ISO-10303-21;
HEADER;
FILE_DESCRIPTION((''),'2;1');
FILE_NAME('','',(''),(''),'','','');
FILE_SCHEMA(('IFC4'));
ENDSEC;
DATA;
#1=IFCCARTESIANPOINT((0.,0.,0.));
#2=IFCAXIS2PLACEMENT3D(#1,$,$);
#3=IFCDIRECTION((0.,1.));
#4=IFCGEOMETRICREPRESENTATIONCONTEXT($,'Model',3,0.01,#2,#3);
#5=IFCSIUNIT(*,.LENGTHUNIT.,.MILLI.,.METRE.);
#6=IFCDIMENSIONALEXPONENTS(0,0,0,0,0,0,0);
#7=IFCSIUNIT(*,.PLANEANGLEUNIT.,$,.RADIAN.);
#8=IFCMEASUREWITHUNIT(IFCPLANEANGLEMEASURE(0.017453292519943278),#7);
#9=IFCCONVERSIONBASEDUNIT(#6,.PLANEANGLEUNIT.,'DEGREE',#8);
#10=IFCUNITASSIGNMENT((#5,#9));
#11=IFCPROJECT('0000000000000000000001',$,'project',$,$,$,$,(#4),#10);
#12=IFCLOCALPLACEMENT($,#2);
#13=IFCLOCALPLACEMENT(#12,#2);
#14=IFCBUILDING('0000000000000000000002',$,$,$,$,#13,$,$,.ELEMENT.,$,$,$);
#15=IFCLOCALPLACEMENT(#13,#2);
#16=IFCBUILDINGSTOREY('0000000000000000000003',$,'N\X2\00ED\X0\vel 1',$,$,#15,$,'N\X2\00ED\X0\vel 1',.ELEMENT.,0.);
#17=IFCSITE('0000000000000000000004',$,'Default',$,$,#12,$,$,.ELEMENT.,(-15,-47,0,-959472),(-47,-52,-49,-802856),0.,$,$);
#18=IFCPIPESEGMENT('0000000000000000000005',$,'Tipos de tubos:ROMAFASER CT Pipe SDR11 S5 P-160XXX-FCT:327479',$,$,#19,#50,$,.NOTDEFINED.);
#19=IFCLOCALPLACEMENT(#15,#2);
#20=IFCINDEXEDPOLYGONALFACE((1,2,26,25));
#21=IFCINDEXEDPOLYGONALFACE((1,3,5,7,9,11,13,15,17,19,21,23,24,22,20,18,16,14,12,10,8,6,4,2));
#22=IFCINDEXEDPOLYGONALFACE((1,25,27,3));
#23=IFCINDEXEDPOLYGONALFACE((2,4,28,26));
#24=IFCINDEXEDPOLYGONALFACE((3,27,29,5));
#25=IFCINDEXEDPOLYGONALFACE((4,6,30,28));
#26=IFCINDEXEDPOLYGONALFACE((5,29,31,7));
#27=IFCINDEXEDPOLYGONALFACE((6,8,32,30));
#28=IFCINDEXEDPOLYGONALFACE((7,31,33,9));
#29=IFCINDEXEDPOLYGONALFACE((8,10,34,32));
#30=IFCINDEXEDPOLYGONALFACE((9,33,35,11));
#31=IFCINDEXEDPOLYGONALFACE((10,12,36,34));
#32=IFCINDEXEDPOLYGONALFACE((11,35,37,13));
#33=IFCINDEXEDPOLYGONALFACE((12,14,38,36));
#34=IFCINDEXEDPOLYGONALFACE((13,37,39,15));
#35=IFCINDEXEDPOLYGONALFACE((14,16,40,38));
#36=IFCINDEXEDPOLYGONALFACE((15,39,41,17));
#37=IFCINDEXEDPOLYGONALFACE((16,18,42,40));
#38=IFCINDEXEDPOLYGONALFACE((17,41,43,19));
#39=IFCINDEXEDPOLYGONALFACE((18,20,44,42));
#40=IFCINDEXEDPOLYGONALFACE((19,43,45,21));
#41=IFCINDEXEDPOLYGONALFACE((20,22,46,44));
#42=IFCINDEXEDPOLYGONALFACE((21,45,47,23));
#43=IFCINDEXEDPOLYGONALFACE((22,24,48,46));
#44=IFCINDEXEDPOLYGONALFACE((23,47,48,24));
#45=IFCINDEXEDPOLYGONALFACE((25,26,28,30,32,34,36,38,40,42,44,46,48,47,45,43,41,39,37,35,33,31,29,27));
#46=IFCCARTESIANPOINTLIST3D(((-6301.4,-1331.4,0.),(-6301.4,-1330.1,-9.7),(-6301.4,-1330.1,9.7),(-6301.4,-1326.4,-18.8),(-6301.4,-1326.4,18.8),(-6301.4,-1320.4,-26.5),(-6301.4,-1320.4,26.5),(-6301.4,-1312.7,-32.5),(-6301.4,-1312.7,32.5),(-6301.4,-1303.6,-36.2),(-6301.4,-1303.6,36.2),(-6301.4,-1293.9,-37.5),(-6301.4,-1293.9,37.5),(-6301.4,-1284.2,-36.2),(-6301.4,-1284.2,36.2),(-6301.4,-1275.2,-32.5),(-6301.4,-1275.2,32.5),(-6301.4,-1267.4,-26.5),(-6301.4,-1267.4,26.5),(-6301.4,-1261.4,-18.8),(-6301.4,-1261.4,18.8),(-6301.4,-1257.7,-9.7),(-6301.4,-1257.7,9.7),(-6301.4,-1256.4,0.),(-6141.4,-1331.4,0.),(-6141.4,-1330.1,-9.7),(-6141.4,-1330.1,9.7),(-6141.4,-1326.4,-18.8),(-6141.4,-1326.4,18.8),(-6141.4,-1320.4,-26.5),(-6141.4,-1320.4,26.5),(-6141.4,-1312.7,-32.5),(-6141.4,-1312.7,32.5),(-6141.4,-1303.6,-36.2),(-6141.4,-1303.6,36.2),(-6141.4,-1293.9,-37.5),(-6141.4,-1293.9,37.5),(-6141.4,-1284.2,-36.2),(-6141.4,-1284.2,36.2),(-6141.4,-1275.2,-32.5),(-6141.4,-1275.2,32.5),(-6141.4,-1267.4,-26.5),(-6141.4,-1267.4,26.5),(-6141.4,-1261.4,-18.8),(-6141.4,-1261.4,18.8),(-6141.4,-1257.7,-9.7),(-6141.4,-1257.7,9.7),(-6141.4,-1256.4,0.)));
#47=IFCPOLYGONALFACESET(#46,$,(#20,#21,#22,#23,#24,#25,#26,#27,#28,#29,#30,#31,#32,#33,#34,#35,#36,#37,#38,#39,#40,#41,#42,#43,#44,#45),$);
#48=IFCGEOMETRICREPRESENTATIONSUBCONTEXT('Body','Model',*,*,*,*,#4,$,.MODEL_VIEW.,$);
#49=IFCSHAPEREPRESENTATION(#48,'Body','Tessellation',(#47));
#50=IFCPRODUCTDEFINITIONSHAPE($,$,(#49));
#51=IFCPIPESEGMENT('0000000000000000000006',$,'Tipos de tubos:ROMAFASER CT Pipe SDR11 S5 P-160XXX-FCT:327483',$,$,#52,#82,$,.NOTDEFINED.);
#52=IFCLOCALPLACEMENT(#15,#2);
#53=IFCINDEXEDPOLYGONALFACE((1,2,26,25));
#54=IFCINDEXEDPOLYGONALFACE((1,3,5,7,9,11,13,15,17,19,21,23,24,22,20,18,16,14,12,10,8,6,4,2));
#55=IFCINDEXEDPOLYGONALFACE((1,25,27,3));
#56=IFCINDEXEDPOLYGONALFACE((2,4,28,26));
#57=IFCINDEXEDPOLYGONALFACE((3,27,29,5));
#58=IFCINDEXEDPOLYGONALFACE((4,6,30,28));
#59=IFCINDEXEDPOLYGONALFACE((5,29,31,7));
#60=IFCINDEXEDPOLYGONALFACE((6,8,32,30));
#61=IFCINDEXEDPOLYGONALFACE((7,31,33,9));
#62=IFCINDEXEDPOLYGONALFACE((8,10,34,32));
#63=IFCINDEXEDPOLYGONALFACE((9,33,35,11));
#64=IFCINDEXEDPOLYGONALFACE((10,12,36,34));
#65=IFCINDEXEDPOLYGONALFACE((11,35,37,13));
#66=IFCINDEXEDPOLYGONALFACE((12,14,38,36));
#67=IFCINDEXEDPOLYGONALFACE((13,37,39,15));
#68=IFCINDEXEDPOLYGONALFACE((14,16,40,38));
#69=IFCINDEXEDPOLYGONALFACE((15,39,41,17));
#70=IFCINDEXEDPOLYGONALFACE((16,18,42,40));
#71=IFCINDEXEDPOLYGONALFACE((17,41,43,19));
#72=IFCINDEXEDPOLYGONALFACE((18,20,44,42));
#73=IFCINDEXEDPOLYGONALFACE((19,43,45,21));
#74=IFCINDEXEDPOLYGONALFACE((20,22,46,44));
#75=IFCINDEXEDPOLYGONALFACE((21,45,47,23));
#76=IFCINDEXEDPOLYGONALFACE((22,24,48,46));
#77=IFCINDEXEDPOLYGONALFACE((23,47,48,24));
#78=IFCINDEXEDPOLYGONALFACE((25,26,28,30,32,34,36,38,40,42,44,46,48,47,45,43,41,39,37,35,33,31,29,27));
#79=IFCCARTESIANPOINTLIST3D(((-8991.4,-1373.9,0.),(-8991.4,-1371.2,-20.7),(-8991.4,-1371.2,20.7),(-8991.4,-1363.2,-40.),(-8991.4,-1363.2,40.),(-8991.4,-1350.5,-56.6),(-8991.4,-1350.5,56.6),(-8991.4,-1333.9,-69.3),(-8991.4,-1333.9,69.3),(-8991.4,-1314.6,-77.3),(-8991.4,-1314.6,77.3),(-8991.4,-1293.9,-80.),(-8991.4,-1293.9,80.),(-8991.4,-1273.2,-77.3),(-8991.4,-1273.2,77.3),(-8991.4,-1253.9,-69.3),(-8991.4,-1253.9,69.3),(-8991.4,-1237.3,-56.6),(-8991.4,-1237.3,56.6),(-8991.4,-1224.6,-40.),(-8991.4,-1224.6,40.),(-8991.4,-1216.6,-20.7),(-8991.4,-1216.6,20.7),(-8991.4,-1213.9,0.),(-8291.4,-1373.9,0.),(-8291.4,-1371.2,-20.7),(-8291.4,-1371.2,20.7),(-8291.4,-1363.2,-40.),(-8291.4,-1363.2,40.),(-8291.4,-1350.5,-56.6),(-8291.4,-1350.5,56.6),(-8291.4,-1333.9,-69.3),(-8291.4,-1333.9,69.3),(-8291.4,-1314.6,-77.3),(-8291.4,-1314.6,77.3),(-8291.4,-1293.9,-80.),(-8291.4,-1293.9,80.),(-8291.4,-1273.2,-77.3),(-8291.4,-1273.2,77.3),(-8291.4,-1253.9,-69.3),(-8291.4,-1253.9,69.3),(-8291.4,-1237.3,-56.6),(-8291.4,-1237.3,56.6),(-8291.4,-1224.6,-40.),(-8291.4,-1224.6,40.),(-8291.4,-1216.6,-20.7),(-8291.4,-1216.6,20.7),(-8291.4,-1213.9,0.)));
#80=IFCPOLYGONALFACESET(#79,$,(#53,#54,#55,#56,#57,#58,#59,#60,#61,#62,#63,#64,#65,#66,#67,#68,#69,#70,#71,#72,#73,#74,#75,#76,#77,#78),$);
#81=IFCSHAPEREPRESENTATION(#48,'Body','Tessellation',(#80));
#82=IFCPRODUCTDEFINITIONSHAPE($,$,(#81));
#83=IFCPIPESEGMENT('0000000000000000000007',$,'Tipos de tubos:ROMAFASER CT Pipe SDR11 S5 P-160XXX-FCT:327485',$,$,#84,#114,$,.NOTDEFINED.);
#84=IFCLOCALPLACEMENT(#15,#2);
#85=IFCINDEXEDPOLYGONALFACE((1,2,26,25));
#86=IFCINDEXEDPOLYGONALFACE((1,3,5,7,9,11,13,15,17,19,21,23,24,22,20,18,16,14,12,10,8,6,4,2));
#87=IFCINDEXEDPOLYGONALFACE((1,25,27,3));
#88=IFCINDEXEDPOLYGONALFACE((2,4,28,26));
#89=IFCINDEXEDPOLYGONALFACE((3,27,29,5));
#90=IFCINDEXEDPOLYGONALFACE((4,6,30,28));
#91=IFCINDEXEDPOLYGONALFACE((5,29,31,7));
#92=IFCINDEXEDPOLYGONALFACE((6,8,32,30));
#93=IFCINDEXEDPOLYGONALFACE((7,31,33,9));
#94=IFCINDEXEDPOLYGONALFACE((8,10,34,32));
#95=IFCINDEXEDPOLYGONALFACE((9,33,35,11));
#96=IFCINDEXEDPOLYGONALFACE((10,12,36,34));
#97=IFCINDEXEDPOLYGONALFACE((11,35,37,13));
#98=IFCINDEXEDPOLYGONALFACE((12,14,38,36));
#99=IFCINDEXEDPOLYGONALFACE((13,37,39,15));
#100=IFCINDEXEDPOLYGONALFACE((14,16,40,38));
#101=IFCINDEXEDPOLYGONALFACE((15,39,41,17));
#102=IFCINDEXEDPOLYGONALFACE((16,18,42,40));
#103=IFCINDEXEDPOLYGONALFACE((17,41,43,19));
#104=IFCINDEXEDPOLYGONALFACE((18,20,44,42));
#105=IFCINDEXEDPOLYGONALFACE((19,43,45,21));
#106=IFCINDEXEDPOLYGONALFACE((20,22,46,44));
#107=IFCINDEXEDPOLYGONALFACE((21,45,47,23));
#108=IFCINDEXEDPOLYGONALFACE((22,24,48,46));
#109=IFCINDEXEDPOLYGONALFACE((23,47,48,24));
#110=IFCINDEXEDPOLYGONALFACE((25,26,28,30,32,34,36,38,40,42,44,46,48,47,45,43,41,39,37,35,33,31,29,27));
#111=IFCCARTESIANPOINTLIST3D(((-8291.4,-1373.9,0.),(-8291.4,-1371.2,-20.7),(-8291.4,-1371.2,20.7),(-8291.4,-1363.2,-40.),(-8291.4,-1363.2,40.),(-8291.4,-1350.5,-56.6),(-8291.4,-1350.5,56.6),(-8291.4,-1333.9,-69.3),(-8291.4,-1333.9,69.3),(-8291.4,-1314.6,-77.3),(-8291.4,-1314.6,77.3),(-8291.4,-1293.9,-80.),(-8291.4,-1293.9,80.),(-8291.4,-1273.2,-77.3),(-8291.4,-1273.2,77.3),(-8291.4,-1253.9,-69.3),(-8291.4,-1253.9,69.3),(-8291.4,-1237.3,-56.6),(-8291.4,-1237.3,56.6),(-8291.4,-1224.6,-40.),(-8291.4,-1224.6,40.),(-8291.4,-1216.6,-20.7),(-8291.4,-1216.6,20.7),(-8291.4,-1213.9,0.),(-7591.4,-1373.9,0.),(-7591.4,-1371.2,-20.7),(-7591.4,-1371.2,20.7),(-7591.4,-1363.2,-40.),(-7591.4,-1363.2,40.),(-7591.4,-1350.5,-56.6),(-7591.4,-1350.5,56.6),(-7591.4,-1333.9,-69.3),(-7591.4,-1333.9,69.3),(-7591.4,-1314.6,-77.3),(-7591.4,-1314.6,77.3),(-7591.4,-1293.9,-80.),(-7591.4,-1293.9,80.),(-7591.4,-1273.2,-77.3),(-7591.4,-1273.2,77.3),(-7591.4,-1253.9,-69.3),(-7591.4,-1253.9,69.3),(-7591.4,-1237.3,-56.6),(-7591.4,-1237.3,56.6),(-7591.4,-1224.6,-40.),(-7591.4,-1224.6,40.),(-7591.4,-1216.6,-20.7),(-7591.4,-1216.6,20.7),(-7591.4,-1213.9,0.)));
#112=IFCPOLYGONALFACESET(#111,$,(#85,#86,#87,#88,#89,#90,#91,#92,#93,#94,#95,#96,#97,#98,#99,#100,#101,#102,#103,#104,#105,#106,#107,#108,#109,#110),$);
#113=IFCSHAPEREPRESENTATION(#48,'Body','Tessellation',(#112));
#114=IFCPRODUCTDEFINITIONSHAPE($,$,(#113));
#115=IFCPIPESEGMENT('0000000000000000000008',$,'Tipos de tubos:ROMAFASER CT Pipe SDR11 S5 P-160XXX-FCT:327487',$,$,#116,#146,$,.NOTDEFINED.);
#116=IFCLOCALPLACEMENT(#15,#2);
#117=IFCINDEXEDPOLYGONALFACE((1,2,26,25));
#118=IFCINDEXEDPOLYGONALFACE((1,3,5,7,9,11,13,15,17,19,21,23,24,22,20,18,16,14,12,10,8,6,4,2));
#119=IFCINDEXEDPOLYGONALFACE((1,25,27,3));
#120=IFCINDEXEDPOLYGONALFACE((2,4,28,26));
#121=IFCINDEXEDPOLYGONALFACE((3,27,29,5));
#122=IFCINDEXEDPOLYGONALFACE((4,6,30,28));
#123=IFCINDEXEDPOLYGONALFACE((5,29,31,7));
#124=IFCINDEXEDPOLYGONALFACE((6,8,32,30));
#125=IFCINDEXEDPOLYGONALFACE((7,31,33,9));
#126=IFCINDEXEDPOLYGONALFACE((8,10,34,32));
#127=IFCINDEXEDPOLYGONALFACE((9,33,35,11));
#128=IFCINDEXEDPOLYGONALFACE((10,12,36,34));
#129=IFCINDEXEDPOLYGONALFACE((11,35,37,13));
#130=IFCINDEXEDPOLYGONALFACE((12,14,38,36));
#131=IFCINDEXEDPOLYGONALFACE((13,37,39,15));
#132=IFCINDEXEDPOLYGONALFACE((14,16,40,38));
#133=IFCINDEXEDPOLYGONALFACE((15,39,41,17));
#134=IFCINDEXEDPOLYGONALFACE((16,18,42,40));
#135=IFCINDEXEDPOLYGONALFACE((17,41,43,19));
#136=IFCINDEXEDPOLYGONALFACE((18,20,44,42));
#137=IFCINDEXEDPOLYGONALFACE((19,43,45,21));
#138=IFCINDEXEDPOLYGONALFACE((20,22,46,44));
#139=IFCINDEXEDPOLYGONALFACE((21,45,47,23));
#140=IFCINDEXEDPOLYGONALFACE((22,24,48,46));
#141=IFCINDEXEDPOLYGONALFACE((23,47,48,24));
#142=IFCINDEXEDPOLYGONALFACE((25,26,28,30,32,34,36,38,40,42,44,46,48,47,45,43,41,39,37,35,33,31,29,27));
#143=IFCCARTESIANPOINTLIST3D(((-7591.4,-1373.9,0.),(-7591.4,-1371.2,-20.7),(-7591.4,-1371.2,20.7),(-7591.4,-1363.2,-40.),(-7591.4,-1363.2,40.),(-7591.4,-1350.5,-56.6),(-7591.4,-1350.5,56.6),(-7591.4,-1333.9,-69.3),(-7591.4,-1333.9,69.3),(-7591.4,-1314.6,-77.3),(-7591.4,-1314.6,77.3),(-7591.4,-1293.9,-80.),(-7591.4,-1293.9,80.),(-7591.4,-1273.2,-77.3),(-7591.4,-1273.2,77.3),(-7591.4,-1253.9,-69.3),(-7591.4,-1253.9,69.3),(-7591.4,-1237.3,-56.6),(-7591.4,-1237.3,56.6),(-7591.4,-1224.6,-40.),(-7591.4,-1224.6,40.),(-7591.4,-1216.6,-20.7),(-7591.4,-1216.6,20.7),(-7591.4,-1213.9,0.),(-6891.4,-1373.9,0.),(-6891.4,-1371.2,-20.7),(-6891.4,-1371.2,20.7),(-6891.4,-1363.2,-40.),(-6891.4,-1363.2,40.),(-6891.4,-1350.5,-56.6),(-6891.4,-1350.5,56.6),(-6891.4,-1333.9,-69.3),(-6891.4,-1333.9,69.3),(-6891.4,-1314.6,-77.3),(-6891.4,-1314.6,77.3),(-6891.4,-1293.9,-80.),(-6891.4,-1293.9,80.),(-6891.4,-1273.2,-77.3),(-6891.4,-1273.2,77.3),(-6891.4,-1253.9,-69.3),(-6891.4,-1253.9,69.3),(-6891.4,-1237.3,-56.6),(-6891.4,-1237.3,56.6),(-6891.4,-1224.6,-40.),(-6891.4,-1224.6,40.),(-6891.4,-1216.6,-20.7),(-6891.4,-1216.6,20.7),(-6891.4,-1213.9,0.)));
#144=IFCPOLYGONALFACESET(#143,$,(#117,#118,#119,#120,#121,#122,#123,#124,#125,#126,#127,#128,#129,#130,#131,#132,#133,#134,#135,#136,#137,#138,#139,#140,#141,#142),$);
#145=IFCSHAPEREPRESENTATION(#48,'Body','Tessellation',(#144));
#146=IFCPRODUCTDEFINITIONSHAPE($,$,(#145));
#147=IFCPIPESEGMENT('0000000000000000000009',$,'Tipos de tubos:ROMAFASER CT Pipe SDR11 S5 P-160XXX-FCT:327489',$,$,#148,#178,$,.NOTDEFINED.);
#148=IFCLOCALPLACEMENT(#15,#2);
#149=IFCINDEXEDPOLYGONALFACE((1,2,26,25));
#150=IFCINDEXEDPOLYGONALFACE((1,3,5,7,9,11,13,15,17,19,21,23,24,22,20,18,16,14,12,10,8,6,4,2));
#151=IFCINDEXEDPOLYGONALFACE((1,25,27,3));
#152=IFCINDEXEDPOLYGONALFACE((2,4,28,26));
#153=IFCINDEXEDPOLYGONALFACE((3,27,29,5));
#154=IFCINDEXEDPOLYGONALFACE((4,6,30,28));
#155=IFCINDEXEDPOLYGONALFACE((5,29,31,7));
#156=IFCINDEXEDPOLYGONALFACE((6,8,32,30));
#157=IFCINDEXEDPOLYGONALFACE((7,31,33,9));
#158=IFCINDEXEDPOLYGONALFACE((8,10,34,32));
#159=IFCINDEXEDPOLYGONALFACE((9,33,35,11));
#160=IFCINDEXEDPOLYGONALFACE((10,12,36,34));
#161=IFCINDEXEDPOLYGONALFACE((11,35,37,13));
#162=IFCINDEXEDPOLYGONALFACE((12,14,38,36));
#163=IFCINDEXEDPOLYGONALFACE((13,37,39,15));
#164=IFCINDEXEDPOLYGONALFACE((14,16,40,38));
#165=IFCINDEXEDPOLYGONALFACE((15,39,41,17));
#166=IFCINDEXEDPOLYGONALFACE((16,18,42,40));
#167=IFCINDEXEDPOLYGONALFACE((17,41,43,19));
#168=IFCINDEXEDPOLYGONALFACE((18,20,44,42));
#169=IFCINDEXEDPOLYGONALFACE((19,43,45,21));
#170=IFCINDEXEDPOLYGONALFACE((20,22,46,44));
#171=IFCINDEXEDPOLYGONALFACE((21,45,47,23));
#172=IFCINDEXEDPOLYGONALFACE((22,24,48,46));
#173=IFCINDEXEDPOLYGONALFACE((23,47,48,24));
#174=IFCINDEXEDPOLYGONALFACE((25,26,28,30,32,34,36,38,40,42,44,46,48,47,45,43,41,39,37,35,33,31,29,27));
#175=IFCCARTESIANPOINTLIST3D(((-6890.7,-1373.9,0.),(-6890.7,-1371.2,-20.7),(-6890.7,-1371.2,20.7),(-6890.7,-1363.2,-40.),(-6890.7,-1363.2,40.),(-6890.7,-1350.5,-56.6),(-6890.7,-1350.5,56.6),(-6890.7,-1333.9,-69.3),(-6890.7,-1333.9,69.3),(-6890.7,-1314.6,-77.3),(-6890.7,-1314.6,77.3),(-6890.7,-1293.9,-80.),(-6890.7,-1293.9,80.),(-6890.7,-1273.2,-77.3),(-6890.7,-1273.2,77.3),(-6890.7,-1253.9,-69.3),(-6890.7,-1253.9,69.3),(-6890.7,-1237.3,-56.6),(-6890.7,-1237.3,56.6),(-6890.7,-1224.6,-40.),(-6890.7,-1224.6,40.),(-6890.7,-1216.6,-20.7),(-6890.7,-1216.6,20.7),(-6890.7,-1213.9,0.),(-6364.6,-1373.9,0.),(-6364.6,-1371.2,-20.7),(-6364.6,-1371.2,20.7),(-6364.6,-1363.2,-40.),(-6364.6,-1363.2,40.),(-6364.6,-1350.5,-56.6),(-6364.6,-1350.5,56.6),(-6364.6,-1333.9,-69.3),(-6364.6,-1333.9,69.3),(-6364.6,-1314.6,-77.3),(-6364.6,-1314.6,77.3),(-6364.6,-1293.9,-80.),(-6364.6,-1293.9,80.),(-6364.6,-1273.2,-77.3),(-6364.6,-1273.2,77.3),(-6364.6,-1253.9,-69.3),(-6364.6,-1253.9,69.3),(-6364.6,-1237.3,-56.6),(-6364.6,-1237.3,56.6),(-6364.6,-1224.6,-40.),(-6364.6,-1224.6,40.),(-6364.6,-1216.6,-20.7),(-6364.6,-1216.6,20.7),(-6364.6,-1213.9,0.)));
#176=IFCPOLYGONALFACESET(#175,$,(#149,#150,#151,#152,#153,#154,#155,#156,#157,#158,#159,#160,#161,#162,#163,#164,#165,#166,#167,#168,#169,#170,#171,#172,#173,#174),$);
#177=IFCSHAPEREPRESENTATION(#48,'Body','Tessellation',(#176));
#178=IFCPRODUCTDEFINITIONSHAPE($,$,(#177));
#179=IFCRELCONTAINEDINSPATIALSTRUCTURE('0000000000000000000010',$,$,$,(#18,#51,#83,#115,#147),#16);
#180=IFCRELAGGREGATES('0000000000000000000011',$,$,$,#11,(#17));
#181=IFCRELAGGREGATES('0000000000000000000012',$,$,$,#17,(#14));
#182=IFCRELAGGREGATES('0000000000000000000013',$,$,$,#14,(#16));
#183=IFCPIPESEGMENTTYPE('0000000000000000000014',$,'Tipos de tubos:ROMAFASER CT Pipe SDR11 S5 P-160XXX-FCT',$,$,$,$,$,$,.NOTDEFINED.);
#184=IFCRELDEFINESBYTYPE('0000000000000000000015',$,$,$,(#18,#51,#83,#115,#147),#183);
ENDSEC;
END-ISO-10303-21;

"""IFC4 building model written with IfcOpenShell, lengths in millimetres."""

from ifc_helpers import new_model, entity, si_unit, converted_unit, direction, frame, origin, place, context, subcontext, project, spatial, arc, indexed_curve, outline, extrude, type_object, element, save


model = new_model("IFC4")

# Units and contexts
model_context = context("Model", 3, precision=0.01, world=origin(), true_north=direction((0.0, 1.0)))
body_context = subcontext(model_context, "Body", "Model", "MODEL_VIEW")
ifc_project = project(units=[si_unit("LENGTHUNIT", "METRE", prefix="MILLI"), converted_unit("PLANEANGLEUNIT", "DEGREE", entity("IfcPlaneAngleMeasure", 0.017453292519943278), si_unit("PLANEANGLEUNIT", "RADIAN"), dimensions=[0, 0, 0, 0, 0, 0, 0])], contexts=[model_context])

# Site, building, storey
site_placement = place(None, origin())
site = spatial("IfcSite", under=ifc_project, at=site_placement, Name="Default", CompositionType="ELEMENT", RefLatitude=(-15, -47, 0, -959472), RefLongitude=(-47, -52, -49, -802856), RefElevation=0.0)
building_placement = place(site_placement, origin())
building = spatial("IfcBuilding", under=site, at=building_placement, CompositionType="ELEMENT")
storey_placement = place(building_placement, origin())
storey = spatial("IfcBuildingStorey", under=building, at=storey_placement, Name="Nível 1", LongName="Nível 1", CompositionType="ELEMENT", Elevation=0.0)

# Pipe segments
pipe_segment_type = type_object("IfcPipeSegmentType", Name="Tipos de tubos:ROMAFASER CT Pipe SDR11 S5 P-160XXX-FCT", PredefinedType="NOTDEFINED")
pipe_segment_1_placement = place(storey_placement, origin())
element("IfcPipeSegment", 1, at=pipe_segment_1_placement, inside=storey, type_object=pipe_segment_type, Name="Tipos de tubos:ROMAFASER CT Pipe SDR11 S5 P-160XXX-FCT:327479", PredefinedType="NOTDEFINED", context=body_context, shape_type="SweptSolid", body=[
    extrude(outline(indexed_curve([(37.5, 0.0), (26.5, 26.5), (0.0, 37.5), (-26.5, 26.5), (-37.5, 0.0), (-26.5, -26.5), (0.0, -37.5), (26.5, -26.5)], segments=[arc(1, 2, 3), arc(3, 4, 5), arc(5, 6, 7), arc(7, 8, 1)], self_intersect=False)), frame((-6301.4, -1293.9, 0.0), z_axis=(1.0, 0.0, 0.0), x_axis=(0.0, 1.0, 0.0)), (0.0, 0.0, 1.0), 160.0),
])
pipe_segment_2_placement = place(storey_placement, origin())
element("IfcPipeSegment", 2, at=pipe_segment_2_placement, inside=storey, type_object=pipe_segment_type, Name="Tipos de tubos:ROMAFASER CT Pipe SDR11 S5 P-160XXX-FCT:327483", PredefinedType="NOTDEFINED", context=body_context, shape_type="SweptSolid", body=[
    extrude(outline(indexed_curve([(80.0, 0.0), (56.6, 56.6), (0.0, 80.0), (-56.6, 56.6), (-80.0, 0.0), (-56.6, -56.6), (0.0, -80.0), (56.6, -56.6)], segments=[arc(1, 2, 3), arc(3, 4, 5), arc(5, 6, 7), arc(7, 8, 1)], self_intersect=False)), frame((-8991.4, -1293.9, 0.0), z_axis=(1.0, 0.0, 0.0), x_axis=(0.0, 1.0, 0.0)), (0.0, 0.0, 1.0), 700.0),
])
pipe_segment_3_placement = place(storey_placement, origin())
element("IfcPipeSegment", 3, at=pipe_segment_3_placement, inside=storey, type_object=pipe_segment_type, Name="Tipos de tubos:ROMAFASER CT Pipe SDR11 S5 P-160XXX-FCT:327485", PredefinedType="NOTDEFINED", context=body_context, shape_type="SweptSolid", body=[
    extrude(outline(indexed_curve([(80.0, 0.0), (56.6, 56.6), (0.0, 80.0), (-56.6, 56.6), (-80.0, 0.0), (-56.6, -56.6), (0.0, -80.0), (56.6, -56.6)], segments=[arc(1, 2, 3), arc(3, 4, 5), arc(5, 6, 7), arc(7, 8, 1)], self_intersect=False)), frame((-8291.4, -1293.9, 0.0), z_axis=(1.0, 0.0, 0.0), x_axis=(0.0, 1.0, 0.0)), (0.0, 0.0, 1.0), 700.0),
])
pipe_segment_4_placement = place(storey_placement, origin())
element("IfcPipeSegment", 4, at=pipe_segment_4_placement, inside=storey, type_object=pipe_segment_type, Name="Tipos de tubos:ROMAFASER CT Pipe SDR11 S5 P-160XXX-FCT:327487", PredefinedType="NOTDEFINED", context=body_context, shape_type="SweptSolid", body=[
    extrude(outline(indexed_curve([(80.0, 0.0), (56.6, 56.6), (0.0, 80.0), (-56.6, 56.6), (-80.0, 0.0), (-56.6, -56.6), (0.0, -80.0), (56.6, -56.6)], segments=[arc(1, 2, 3), arc(3, 4, 5), arc(5, 6, 7), arc(7, 8, 1)], self_intersect=False)), frame((-7591.4, -1293.9, 0.0), z_axis=(1.0, 0.0, 0.0), x_axis=(0.0, -1.0, 0.0)), (0.0, 0.0, 1.0), 700.0),
])
pipe_segment_5_placement = place(storey_placement, origin())
element("IfcPipeSegment", 5, at=pipe_segment_5_placement, inside=storey, type_object=pipe_segment_type, Name="Tipos de tubos:ROMAFASER CT Pipe SDR11 S5 P-160XXX-FCT:327489", PredefinedType="NOTDEFINED", context=body_context, shape_type="SweptSolid", body=[
    extrude(outline(indexed_curve([(80.0, 0.0), (56.6, 56.6), (0.0, 80.0), (-56.6, 56.6), (-80.0, 0.0), (-56.6, -56.6), (0.0, -80.0), (56.6, -56.6)], segments=[arc(1, 2, 3), arc(3, 4, 5), arc(5, 6, 7), arc(7, 8, 1)], self_intersect=False)), frame((-6890.7, -1293.9, 0.0), z_axis=(1.0, 0.0, 0.0), x_axis=(0.0, -1.0, 0.0)), (0.0, 0.0, 1.0), 526.0),
])

save(model, "model.ifc")
